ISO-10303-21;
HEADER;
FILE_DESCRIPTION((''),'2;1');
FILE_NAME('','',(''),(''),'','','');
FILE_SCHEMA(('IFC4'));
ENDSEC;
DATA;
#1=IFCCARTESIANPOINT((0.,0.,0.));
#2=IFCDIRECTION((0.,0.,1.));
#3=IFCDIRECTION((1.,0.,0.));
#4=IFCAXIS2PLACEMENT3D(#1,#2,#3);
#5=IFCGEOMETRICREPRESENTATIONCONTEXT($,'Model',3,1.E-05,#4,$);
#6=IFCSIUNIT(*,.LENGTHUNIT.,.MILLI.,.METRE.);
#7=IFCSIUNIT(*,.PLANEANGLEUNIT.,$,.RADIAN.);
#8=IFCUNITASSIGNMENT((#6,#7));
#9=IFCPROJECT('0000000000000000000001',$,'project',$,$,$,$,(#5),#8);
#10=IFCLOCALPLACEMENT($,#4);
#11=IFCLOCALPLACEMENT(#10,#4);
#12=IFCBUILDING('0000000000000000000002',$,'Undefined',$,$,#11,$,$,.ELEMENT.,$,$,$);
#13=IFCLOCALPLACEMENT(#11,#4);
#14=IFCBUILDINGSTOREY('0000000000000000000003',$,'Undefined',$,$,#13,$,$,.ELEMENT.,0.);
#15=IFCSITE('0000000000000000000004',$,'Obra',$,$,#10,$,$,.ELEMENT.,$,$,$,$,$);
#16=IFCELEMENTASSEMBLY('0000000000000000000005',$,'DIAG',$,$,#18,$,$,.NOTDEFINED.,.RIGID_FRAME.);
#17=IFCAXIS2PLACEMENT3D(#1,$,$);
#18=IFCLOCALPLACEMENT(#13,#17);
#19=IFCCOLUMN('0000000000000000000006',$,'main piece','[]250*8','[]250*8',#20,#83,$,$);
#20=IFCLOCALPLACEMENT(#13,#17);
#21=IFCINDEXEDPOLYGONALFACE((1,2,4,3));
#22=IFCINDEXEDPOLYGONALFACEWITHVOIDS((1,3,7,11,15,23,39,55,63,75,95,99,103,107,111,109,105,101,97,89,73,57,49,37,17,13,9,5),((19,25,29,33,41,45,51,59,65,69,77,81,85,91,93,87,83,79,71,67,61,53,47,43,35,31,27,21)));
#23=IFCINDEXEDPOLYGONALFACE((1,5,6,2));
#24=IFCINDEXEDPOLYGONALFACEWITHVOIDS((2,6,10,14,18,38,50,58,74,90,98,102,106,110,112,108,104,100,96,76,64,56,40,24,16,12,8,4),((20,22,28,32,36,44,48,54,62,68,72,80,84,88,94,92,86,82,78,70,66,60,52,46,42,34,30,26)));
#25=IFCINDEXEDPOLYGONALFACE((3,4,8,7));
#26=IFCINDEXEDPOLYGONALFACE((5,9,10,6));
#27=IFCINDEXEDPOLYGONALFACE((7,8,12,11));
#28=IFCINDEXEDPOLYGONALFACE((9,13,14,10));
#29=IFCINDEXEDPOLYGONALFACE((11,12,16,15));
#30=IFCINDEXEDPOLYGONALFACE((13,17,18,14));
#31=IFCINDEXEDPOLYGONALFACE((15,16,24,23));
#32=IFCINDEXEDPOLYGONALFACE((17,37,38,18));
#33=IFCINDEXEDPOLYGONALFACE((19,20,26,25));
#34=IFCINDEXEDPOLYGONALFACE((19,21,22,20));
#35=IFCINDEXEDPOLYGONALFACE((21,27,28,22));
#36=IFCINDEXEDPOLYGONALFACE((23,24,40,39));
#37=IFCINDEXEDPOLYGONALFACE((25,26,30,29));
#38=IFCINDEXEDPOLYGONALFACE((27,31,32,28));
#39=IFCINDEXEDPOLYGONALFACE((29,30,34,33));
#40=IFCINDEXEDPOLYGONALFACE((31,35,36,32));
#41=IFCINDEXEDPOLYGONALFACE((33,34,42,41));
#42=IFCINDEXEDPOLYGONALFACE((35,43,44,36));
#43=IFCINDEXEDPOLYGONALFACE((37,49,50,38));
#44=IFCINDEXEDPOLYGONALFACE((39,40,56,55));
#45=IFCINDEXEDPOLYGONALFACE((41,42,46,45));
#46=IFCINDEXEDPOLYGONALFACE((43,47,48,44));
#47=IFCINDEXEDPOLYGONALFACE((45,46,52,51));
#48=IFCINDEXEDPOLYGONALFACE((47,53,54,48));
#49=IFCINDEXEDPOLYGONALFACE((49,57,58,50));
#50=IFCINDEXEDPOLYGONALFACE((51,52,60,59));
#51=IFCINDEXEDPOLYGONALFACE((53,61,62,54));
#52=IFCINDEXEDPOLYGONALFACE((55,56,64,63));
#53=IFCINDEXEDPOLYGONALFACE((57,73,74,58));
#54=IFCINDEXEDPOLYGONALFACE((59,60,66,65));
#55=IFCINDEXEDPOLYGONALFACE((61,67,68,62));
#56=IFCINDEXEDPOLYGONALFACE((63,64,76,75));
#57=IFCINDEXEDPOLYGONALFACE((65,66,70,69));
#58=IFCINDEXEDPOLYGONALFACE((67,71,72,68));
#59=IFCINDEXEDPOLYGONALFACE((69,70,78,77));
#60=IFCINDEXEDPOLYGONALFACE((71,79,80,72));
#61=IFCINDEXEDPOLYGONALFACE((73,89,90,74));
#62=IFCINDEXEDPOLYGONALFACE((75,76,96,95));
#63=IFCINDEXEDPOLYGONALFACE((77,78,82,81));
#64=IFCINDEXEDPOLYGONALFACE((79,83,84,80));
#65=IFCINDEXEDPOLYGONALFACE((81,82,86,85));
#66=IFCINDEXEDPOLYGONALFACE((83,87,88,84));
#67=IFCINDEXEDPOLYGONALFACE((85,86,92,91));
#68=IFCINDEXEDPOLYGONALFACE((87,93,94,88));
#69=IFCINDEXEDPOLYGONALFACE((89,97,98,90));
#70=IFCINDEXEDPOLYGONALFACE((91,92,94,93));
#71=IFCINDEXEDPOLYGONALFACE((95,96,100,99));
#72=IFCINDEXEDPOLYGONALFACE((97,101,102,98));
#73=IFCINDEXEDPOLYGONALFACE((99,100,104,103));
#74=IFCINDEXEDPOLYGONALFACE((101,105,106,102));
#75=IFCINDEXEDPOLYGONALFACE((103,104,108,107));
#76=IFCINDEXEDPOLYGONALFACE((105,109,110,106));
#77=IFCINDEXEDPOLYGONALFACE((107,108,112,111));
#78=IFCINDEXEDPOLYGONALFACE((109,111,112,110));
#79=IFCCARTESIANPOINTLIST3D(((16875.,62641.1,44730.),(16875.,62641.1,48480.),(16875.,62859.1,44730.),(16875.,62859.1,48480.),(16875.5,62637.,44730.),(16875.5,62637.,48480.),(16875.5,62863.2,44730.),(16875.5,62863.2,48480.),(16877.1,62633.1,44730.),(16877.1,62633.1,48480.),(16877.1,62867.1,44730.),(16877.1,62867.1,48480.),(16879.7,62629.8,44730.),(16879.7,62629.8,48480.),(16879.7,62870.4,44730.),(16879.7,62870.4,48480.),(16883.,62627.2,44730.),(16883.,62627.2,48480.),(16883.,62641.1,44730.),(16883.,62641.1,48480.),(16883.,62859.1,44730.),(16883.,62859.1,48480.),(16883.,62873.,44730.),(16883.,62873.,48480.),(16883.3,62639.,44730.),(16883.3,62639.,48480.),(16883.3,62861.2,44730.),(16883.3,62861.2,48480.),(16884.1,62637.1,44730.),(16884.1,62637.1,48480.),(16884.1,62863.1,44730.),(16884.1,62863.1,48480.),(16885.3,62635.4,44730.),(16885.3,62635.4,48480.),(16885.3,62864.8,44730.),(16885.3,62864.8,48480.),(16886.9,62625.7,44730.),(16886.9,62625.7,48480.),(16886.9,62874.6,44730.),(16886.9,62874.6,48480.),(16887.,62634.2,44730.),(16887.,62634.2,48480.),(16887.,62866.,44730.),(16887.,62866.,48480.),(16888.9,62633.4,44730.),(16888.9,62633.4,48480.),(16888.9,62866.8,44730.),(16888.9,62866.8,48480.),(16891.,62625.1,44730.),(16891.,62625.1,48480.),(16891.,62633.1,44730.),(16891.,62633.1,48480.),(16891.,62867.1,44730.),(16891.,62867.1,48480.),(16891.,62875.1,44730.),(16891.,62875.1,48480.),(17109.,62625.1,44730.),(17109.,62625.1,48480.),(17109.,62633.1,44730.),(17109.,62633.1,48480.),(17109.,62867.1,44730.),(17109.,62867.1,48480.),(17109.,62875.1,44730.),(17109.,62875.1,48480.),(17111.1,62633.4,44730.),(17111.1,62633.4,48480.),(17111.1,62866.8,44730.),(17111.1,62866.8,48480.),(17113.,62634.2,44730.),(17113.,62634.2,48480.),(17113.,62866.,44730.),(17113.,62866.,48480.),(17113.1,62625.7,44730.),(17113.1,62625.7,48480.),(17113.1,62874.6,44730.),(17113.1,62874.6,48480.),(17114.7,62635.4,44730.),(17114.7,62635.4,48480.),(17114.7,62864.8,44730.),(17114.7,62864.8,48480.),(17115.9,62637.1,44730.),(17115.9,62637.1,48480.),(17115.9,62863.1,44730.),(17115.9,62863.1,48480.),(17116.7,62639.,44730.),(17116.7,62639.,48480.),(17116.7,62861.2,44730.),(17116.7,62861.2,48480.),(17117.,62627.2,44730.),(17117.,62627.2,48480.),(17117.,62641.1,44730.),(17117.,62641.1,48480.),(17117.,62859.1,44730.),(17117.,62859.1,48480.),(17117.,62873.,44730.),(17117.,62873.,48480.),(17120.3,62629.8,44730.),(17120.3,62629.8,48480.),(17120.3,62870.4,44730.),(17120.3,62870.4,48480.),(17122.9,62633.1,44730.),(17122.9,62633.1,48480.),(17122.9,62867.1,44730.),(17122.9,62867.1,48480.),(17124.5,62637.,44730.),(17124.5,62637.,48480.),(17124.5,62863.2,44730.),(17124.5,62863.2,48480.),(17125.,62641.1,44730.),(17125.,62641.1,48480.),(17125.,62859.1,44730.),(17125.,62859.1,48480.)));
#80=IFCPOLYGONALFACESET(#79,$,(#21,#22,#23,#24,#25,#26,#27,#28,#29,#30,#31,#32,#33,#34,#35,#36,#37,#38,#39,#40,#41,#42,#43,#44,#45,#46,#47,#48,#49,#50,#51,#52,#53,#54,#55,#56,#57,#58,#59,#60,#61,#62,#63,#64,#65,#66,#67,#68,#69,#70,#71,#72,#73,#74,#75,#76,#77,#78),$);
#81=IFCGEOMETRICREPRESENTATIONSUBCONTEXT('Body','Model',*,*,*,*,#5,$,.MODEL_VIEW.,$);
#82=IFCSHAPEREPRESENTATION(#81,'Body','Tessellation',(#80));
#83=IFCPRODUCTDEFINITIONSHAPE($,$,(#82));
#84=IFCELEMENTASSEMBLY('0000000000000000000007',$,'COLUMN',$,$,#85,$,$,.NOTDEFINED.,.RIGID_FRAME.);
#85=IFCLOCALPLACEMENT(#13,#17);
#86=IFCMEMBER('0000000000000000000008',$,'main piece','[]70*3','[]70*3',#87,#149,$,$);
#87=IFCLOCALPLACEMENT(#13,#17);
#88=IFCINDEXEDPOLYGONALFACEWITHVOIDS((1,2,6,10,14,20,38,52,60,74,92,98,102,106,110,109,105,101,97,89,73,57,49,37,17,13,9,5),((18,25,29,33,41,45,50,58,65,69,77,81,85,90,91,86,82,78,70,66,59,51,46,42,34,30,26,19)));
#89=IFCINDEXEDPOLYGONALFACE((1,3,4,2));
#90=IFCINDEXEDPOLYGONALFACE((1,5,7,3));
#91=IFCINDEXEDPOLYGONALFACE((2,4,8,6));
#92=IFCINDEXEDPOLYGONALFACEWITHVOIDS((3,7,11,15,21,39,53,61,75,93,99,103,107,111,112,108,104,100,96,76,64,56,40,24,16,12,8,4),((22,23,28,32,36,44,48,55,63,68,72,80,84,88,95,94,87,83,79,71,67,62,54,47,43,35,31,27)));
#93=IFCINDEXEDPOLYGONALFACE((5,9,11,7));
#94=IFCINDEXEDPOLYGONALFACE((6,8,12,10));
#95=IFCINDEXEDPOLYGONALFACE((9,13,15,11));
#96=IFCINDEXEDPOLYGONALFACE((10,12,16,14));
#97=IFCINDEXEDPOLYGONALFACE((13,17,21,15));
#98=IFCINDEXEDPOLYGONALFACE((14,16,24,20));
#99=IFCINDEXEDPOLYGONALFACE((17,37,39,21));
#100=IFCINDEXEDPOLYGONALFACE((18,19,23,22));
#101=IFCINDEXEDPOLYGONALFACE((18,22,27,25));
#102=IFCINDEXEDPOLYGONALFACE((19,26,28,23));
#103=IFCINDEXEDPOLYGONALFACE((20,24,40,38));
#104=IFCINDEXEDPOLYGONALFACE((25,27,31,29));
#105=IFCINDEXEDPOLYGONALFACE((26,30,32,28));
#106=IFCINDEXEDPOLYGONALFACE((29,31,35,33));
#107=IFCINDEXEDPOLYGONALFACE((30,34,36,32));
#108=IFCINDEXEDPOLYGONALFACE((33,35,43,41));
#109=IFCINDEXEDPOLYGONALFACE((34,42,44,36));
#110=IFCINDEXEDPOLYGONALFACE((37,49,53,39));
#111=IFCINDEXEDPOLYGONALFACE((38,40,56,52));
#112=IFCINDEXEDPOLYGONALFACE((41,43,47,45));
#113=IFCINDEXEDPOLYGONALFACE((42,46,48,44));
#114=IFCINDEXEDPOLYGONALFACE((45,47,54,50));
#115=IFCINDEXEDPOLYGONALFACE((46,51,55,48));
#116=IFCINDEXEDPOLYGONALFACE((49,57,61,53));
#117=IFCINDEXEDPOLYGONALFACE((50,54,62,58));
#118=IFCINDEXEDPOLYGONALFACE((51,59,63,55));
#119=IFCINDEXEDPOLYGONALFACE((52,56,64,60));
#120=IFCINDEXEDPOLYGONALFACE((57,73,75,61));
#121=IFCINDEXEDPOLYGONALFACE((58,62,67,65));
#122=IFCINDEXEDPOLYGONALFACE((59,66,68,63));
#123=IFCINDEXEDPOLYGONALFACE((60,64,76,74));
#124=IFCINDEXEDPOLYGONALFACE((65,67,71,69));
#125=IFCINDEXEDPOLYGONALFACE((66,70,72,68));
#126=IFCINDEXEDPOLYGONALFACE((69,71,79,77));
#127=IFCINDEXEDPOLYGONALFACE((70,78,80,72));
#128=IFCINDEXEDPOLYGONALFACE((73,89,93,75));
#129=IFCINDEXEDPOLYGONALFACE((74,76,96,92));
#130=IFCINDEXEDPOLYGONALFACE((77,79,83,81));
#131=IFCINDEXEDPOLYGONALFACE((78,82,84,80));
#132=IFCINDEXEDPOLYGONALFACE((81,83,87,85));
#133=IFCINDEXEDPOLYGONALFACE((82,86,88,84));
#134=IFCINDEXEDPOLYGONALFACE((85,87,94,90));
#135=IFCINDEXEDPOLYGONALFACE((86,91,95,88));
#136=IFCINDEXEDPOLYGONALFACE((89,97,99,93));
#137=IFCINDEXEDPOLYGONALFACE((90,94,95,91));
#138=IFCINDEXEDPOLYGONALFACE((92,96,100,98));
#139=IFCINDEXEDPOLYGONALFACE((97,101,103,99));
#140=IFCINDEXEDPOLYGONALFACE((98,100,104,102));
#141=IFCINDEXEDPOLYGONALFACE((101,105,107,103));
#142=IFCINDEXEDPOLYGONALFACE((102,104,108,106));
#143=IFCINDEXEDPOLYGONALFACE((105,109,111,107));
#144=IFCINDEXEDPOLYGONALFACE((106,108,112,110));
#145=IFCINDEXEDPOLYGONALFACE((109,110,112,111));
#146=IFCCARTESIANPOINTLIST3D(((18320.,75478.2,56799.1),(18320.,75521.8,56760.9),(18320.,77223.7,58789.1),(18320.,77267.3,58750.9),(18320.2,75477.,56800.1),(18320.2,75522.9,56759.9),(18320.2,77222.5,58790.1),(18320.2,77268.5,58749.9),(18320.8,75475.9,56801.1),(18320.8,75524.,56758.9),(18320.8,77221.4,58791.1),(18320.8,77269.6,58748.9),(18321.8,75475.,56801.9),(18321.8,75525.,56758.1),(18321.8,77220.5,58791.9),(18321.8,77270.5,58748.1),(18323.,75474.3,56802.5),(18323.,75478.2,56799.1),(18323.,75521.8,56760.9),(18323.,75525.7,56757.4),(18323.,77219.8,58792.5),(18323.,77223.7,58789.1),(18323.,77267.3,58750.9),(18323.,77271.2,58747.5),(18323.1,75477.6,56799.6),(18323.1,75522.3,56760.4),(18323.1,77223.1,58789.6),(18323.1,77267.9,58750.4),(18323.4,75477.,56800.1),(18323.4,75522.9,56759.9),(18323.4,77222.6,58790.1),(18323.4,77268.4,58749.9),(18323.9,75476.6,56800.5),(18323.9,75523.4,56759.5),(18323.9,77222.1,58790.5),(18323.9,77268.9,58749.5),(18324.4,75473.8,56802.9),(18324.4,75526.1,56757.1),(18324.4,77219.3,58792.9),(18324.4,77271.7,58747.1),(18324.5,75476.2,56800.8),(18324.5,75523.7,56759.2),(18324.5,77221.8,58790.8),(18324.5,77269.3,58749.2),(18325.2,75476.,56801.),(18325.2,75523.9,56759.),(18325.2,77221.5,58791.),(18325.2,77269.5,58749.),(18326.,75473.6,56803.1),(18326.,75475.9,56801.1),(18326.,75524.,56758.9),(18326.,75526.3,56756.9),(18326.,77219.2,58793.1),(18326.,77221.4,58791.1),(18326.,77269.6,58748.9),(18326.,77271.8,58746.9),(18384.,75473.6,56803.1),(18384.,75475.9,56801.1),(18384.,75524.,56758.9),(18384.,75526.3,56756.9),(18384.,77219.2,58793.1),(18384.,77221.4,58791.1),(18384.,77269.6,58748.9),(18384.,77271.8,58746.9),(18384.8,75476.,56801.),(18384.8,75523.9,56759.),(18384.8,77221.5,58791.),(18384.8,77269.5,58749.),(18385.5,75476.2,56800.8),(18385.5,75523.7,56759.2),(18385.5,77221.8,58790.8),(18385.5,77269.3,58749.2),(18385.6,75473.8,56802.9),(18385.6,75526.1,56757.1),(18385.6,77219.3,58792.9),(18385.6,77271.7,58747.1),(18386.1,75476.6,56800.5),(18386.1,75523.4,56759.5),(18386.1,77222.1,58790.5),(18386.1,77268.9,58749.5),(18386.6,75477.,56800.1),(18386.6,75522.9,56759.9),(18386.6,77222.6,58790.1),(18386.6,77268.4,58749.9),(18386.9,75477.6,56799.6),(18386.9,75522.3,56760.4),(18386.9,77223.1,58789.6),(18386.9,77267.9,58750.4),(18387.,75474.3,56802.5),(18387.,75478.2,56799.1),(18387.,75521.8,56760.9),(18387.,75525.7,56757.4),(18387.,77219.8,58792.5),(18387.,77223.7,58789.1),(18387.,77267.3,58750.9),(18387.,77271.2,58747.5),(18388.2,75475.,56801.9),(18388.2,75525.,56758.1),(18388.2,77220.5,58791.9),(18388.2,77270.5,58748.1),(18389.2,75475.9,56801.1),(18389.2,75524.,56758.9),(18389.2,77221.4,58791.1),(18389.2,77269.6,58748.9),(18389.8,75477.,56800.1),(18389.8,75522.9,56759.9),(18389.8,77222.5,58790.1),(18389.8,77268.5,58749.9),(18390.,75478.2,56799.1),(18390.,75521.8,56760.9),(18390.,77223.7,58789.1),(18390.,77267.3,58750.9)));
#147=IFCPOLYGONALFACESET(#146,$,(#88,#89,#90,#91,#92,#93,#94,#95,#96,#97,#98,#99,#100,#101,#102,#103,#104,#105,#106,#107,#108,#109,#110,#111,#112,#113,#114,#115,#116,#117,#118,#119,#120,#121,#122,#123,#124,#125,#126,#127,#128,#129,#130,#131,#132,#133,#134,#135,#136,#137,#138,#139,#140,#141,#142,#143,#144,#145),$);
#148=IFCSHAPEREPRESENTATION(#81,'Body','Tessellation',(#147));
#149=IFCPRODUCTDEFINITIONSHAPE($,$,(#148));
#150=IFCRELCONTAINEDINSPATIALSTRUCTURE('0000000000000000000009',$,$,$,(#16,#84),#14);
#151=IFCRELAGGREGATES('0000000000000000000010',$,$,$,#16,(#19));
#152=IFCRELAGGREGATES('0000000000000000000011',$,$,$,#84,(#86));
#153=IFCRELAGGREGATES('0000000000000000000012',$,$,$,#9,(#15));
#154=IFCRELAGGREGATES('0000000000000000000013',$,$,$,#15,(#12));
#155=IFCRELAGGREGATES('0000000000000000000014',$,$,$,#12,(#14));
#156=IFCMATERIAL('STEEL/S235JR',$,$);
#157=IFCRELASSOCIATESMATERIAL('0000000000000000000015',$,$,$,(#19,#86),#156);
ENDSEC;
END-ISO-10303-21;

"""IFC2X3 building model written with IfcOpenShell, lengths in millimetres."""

from ifc_helpers import new_model, si_unit, frame, origin_with_axes, origin_2d_with_axis, place, context, subcontext, project, spatial, hollow_rectangle, extrude, material, element, aggregate, save


model = new_model("IFC2X3")

# Units and contexts
model_context = context("Model", 3, precision=1e-05, world=origin_with_axes())
body_context = subcontext(model_context, "Body", "Model", "MODEL_VIEW")
ifc_project = project(units=[si_unit("LENGTHUNIT", "METRE", prefix="MILLI"), si_unit("PLANEANGLEUNIT", "RADIAN")], contexts=[model_context])

# Site, building, storey
site_placement = place(None, origin_with_axes())
site = spatial("IfcSite", under=ifc_project, at=site_placement, Name="Obra", CompositionType="ELEMENT")
building_placement = place(site_placement, origin_with_axes())
building = spatial("IfcBuilding", under=site, at=building_placement, Name="Undefined", CompositionType="ELEMENT")
storey_placement = place(building_placement, origin_with_axes())
storey = spatial("IfcBuildingStorey", under=building, at=storey_placement, Name="Undefined", CompositionType="ELEMENT", Elevation=0.0)

# Element assembly, column
ifc_material = material(Name="STEEL/S235JR")
assembly_1_placement = place(storey_placement, origin_with_axes())
assembly_1 = element("IfcElementAssembly", 1, at=assembly_1_placement, inside=storey, Name="DIAG", AssemblyPlace="NOTDEFINED", PredefinedType="RIGID_FRAME")
column_1_placement = place(assembly_1_placement, frame((17000.0, 62750.1, 44730.0), z_axis=(0.0, 0.0, 1.0), x_axis=(-1.0, 0.0, 0.0)))
column_1 = element("IfcColumn", 2, at=column_1_placement, material=ifc_material, Name="main piece", Description="[]250*8", ObjectType="[]250*8", context=body_context, shape_type="SweptSolid", body=[
    extrude(hollow_rectangle(XDim=250.0, YDim=250.0, WallThickness=8.0, InnerFilletRadius=8.0, OuterFilletRadius=16.0, at=origin_2d_with_axis()), frame((0.0, 0.0, 3750.0), z_axis=(0.0, 0.0, -1.0), x_axis=(0.0, 1.0, 0.0)), (0.0, 0.0, 1.0), 3750.0),
])
aggregate(assembly_1, [column_1])

# Element assembly, member
assembly_2_placement = place(storey_placement, origin_with_axes())
assembly_2 = element("IfcElementAssembly", 3, at=assembly_2_placement, inside=storey, Name="COLUMN", AssemblyPlace="NOTDEFINED", PredefinedType="RIGID_FRAME")
member_1_placement = place(assembly_2_placement, frame((18355.0, 75500.0, 56780.0), z_axis=(-1.0, 0.0, 0.0), x_axis=(0.0, 0.659423, 0.751772)))
member_1 = element("IfcMember", 4, at=member_1_placement, material=ifc_material, Name="main piece", Description="[]70*3", ObjectType="[]70*3", context=body_context, shape_type="SweptSolid", body=[
    extrude(hollow_rectangle(XDim=70.0, YDim=70.0, WallThickness=3.0, InnerFilletRadius=3.0, OuterFilletRadius=6.0, at=origin_2d_with_axis()), frame((2647.1, 0.0, 0.0), z_axis=(-1.0, 0.0, 0.0), x_axis=(0.0, -1.0, 0.0)), (0.0, 0.0, 1.0), 2647.1),
])
aggregate(assembly_2, [member_1])

save(model, "model.ifc")
